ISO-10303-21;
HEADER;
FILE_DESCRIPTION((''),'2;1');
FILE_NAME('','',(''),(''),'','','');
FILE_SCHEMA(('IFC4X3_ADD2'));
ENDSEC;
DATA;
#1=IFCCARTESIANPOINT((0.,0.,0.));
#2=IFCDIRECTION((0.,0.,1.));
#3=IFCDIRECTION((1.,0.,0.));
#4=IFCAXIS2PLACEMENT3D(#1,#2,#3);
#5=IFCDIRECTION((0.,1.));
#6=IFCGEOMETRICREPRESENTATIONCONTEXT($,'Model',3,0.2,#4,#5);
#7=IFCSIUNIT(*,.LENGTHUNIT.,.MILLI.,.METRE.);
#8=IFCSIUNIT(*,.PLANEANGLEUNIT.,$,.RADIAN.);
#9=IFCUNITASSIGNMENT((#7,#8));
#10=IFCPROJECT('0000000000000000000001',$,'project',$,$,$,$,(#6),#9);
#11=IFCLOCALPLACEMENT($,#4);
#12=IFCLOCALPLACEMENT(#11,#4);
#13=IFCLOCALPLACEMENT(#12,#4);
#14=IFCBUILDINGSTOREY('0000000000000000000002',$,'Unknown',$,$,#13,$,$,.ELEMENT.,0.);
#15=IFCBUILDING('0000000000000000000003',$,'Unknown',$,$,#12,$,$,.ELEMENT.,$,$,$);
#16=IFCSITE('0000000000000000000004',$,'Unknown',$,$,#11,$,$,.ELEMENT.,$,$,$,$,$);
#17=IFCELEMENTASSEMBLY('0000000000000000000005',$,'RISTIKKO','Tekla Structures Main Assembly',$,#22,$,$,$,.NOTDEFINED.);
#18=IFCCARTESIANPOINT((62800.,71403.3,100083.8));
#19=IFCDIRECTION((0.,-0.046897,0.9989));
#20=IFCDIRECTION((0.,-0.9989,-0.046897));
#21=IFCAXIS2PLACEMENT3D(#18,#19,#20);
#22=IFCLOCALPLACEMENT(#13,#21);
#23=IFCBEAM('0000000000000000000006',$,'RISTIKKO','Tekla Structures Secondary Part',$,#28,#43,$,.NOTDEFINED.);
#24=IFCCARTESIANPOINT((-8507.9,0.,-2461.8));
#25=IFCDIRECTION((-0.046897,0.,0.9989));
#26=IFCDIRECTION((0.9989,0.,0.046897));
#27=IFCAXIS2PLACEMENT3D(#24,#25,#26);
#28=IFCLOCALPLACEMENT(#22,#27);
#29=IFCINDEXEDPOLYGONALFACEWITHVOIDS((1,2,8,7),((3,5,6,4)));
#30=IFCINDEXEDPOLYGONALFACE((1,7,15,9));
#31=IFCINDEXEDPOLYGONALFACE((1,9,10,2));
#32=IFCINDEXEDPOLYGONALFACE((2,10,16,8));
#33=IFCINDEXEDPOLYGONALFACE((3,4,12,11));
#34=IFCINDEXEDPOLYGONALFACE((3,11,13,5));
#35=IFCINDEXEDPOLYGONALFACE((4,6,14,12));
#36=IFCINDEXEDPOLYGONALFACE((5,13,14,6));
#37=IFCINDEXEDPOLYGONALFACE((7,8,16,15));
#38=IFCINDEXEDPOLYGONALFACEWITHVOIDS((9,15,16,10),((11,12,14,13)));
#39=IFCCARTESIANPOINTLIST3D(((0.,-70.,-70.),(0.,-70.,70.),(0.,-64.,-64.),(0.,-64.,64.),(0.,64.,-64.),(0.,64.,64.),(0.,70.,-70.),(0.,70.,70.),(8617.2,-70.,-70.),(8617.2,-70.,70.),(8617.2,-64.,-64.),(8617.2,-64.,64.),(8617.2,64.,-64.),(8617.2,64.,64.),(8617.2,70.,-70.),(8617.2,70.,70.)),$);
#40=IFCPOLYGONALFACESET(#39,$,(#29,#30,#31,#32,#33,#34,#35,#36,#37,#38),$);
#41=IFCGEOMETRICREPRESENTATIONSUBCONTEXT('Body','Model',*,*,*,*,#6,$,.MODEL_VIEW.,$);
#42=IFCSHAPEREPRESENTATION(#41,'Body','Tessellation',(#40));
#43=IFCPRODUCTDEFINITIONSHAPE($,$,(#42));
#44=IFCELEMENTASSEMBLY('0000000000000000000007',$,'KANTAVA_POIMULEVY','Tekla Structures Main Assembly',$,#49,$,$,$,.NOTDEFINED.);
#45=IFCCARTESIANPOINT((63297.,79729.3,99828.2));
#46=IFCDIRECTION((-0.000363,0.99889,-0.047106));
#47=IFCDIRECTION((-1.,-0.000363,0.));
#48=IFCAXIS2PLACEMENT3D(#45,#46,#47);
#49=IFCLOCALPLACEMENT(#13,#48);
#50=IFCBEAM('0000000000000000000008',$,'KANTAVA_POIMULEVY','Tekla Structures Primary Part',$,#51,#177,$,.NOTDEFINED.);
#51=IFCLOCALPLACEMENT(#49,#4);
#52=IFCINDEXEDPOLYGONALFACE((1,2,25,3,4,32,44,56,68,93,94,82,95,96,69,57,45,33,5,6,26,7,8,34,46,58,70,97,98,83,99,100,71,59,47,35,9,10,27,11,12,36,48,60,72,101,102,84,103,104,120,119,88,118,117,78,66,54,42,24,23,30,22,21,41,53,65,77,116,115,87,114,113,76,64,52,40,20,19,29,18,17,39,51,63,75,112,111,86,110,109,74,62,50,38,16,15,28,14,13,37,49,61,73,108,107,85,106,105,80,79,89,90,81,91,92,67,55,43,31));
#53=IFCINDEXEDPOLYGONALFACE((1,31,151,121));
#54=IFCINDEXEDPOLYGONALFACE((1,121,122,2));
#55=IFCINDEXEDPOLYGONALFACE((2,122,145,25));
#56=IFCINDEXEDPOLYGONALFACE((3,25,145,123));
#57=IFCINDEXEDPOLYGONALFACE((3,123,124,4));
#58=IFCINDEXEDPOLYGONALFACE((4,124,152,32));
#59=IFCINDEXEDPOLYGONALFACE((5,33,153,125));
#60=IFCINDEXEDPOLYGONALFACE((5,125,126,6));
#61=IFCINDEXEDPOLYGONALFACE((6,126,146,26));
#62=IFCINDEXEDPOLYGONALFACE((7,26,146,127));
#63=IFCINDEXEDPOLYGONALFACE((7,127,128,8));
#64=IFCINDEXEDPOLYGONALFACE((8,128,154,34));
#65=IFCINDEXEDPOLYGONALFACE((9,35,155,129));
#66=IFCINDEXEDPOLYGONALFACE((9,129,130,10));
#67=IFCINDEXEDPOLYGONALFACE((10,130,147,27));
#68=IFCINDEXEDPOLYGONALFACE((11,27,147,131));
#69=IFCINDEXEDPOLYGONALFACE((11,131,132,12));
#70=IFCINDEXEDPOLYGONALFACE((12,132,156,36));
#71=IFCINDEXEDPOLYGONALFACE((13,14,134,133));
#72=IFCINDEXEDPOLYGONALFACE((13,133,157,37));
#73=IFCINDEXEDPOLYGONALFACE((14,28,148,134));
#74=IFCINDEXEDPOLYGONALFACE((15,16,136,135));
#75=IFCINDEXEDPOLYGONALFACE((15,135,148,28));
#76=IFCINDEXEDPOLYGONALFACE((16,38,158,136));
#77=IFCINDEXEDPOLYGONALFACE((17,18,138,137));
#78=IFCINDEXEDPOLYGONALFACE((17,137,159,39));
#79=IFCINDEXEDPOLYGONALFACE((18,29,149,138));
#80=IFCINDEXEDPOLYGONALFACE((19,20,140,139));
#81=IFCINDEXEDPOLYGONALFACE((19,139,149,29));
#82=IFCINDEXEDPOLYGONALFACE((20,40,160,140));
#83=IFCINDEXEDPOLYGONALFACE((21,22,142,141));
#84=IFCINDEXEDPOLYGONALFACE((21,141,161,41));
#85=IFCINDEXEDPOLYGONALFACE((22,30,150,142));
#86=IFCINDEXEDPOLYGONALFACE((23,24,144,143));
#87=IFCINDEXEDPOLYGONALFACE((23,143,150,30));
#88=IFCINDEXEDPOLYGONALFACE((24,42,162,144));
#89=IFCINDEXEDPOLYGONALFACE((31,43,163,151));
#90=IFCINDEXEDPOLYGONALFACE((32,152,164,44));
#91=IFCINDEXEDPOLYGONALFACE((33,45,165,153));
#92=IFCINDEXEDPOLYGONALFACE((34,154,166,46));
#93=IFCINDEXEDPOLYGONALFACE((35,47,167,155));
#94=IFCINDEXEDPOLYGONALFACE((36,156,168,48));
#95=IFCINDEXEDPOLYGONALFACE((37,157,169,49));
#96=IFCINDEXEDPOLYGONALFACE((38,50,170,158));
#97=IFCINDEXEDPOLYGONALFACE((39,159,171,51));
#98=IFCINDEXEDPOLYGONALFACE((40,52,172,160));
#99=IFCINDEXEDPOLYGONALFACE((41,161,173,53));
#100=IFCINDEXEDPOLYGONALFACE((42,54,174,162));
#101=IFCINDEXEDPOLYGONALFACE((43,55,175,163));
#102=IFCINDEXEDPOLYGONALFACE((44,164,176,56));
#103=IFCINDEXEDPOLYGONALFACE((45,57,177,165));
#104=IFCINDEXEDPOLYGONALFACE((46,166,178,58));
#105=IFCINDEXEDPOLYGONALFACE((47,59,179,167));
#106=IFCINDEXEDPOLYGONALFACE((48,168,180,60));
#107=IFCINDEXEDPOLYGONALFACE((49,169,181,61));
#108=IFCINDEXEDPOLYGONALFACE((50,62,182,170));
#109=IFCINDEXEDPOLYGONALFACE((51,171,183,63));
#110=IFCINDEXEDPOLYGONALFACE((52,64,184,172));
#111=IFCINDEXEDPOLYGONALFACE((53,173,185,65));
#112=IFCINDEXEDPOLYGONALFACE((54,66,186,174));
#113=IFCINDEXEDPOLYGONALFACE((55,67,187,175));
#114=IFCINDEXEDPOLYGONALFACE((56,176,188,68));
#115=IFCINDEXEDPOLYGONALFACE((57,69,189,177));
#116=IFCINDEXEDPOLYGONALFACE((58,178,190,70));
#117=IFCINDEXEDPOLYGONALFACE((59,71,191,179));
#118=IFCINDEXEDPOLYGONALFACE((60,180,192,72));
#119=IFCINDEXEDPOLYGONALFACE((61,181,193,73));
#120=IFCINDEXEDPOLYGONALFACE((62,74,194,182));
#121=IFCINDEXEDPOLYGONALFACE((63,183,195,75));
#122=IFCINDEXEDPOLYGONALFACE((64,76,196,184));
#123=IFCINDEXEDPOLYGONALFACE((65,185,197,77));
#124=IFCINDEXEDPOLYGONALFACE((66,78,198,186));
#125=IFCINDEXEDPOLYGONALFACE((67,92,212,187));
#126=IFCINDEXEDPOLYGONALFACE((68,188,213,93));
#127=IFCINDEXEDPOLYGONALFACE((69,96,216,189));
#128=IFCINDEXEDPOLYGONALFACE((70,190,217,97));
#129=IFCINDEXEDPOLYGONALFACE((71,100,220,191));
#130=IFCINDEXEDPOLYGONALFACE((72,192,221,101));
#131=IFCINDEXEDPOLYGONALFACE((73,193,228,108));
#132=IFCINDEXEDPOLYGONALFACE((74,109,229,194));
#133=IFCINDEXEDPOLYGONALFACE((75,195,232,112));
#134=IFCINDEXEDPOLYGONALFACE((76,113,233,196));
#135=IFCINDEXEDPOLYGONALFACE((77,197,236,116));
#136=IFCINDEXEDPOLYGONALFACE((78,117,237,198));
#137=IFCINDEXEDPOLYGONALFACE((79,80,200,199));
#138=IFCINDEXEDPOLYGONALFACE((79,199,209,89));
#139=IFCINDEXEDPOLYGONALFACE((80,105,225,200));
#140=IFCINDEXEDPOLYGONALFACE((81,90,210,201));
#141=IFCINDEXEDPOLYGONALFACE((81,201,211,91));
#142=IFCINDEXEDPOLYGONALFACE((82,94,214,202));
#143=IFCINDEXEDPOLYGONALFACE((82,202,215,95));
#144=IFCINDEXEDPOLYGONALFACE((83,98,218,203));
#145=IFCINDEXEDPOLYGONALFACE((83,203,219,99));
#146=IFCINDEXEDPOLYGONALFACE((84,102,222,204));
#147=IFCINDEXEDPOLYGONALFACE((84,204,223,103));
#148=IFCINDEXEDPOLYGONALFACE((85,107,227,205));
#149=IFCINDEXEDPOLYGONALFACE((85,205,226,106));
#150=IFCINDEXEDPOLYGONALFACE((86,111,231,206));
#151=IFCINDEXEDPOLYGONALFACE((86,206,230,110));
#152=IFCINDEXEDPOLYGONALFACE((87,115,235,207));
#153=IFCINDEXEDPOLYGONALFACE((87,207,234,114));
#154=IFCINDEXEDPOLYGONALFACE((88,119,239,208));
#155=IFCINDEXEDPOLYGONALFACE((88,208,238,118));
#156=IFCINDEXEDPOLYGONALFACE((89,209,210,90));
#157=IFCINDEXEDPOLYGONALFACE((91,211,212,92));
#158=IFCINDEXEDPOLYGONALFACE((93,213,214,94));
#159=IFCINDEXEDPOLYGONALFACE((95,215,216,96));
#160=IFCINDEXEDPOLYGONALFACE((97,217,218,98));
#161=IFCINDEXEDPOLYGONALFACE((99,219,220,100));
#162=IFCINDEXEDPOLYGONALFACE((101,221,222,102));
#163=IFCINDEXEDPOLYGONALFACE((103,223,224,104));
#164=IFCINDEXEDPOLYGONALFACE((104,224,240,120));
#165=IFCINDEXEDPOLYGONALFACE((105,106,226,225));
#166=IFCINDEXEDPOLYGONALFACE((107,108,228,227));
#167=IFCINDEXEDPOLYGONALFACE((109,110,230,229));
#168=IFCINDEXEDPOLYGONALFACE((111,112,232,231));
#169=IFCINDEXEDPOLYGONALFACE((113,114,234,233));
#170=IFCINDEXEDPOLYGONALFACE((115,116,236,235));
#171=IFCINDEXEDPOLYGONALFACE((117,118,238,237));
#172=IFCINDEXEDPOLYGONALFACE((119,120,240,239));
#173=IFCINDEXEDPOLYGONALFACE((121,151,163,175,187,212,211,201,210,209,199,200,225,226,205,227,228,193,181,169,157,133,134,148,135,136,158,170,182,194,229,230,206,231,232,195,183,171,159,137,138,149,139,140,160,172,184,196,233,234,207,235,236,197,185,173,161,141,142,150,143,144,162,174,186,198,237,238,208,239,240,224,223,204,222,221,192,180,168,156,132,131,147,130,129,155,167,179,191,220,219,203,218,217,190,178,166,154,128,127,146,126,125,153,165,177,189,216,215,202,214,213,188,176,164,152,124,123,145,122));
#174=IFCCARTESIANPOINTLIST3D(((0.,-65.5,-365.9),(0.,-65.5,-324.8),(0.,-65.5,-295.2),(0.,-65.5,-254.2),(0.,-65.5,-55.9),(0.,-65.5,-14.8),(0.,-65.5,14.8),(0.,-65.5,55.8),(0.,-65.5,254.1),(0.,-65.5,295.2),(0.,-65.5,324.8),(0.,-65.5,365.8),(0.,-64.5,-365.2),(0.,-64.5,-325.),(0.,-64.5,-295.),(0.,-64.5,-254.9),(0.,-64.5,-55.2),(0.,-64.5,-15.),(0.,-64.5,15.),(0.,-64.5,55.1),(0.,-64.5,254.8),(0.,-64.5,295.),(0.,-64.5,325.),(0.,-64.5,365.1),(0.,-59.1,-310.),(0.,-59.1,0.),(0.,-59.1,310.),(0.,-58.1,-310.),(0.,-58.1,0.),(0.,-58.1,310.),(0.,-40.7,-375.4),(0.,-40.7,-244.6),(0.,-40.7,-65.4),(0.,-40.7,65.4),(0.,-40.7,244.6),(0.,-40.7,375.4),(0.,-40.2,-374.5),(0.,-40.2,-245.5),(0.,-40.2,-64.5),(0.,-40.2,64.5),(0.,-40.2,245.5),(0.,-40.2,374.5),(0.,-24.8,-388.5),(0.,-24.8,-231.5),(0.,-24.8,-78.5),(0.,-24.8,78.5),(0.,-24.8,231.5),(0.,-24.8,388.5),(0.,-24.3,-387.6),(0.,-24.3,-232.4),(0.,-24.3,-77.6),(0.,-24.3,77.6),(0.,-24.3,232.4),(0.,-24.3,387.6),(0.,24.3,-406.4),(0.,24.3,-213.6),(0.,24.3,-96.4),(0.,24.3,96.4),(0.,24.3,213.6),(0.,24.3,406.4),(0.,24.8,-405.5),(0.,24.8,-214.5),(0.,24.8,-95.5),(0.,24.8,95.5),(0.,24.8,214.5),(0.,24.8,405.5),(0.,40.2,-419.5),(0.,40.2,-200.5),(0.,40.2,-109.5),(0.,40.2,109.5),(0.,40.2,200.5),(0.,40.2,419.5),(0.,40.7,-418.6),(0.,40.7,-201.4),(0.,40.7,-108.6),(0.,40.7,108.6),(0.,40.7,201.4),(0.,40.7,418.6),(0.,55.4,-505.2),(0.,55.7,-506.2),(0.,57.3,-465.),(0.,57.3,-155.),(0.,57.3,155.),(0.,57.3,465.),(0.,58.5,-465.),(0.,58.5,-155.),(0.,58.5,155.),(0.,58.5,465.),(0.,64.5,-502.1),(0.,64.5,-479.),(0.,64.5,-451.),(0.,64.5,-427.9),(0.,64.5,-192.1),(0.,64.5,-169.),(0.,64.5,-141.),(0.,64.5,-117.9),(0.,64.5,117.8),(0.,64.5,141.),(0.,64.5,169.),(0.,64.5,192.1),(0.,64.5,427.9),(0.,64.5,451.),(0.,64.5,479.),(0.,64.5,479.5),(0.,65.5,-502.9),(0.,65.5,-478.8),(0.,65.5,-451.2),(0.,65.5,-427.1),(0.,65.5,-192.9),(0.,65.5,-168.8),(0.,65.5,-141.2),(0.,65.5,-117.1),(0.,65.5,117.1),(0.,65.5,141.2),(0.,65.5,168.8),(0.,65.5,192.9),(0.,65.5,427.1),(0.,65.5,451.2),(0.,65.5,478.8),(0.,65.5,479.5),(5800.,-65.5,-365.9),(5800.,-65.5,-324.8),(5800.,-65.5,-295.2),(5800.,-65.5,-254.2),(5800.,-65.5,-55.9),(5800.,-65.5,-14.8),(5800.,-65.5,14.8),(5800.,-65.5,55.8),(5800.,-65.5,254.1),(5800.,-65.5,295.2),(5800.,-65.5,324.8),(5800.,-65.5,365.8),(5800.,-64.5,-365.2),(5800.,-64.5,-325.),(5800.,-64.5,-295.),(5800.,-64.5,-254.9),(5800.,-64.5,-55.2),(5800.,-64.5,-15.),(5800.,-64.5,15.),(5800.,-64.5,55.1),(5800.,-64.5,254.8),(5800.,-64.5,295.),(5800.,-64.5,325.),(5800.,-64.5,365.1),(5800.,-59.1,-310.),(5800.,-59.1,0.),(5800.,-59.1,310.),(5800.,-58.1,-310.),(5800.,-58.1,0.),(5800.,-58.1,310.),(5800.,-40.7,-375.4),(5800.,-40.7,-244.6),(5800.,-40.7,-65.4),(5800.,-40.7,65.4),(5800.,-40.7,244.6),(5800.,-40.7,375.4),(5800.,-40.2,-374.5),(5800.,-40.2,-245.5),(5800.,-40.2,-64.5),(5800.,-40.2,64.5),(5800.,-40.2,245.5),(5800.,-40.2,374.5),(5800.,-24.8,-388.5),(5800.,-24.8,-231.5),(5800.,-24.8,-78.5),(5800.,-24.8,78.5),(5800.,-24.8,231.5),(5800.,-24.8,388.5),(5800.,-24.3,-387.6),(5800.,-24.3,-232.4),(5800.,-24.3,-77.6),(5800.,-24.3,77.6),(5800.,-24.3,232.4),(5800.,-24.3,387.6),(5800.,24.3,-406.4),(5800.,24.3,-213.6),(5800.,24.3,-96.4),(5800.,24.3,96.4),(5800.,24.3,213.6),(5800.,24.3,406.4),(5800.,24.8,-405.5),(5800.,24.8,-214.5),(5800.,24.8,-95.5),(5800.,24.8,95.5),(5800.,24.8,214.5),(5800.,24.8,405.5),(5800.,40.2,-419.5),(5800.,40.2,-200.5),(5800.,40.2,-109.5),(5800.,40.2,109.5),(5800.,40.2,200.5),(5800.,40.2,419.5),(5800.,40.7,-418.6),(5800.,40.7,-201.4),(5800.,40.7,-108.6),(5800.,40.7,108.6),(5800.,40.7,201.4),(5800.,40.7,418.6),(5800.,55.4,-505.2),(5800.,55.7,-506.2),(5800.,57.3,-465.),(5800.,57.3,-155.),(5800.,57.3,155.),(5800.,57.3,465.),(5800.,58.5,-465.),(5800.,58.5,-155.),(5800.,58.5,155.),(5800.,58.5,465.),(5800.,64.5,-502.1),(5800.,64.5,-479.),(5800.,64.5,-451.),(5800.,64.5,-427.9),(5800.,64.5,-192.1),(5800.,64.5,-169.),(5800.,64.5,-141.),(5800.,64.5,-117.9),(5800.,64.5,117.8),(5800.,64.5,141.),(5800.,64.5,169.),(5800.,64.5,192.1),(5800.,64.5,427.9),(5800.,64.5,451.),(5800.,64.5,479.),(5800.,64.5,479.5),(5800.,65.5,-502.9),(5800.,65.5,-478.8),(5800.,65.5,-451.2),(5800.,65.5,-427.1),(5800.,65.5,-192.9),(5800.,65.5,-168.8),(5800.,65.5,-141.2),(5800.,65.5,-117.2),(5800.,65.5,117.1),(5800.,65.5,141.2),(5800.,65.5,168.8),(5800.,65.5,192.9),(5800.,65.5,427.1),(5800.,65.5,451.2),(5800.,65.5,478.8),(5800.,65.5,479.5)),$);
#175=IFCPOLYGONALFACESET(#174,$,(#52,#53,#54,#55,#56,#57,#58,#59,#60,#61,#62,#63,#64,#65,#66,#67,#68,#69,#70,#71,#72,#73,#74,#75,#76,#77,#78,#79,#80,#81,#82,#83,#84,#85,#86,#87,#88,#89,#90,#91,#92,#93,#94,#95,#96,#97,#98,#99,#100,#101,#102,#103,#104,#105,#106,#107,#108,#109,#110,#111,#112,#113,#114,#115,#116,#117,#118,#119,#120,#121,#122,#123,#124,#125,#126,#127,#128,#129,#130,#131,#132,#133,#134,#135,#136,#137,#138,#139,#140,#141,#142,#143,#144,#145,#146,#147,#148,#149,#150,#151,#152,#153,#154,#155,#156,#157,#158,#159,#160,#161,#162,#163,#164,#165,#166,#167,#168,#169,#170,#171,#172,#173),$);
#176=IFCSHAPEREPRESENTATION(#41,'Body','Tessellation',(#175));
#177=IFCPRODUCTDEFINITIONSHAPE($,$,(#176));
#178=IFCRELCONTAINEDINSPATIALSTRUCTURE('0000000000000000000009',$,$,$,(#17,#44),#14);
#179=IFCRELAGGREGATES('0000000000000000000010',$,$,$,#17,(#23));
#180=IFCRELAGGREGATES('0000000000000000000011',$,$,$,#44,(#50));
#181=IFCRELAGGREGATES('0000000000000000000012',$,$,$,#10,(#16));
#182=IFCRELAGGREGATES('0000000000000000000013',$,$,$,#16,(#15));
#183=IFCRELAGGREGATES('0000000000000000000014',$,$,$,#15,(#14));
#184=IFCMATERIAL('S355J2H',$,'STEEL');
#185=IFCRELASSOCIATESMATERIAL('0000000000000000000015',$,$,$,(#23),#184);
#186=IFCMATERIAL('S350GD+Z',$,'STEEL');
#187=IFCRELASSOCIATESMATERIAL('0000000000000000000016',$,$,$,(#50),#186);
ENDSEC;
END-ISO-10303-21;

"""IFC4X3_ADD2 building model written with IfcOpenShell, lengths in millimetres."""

from ifc_helpers import new_model, si_unit, direction, frame, origin_with_axes, place, context, subcontext, project, spatial, line, indexed_curve, outline, extrude, material, element, aggregate, save


model = new_model("IFC4X3_ADD2")

# Units and contexts
model_context = context("Model", 3, precision=0.2, world=origin_with_axes(), true_north=direction((0.0, 1.0)))
body_context = subcontext(model_context, "Body", "Model", "MODEL_VIEW")
ifc_project = project(units=[si_unit("LENGTHUNIT", "METRE", prefix="MILLI"), si_unit("PLANEANGLEUNIT", "RADIAN")], contexts=[model_context])

# Site, building, storey
site_placement = place(None, origin_with_axes())
site = spatial("IfcSite", under=ifc_project, at=site_placement, Name="Unknown", CompositionType="ELEMENT")
building_placement = place(site_placement, origin_with_axes())
building = spatial("IfcBuilding", under=site, at=building_placement, Name="Unknown", CompositionType="ELEMENT")
storey_placement = place(building_placement, origin_with_axes())
storey = spatial("IfcBuildingStorey", under=building, at=storey_placement, Name="Unknown", CompositionType="ELEMENT", Elevation=0.0)

# Element assembly, beam
assembly_1_placement = place(storey_placement, frame((62800.0, 71403.3, 100083.8), z_axis=(0.0, -0.046897, 0.9989), x_axis=(0.0, -0.9989, -0.046897)))
assembly_1 = element("IfcElementAssembly", 1, at=assembly_1_placement, inside=storey, Name="RISTIKKO", Description="Tekla Structures Main Assembly", PredefinedType="NOTDEFINED")
ifc_material_1 = material(Name="S355J2H", Category="STEEL")
beam_1_placement = place(assembly_1_placement, frame((-8507.9, 0.0, -2461.8), z_axis=(-0.046897, 0.0, 0.9989), x_axis=(0.9989, 0.0, 0.046897)))
beam_1 = element("IfcBeam", 2, at=beam_1_placement, material=ifc_material_1, Name="RISTIKKO", Description="Tekla Structures Secondary Part", PredefinedType="NOTDEFINED", context=body_context, shape_type="SolidModel", body=[
    extrude(outline(indexed_curve([(-70.0, -70.0), (70.0, -70.0), (70.0, 70.0), (-70.0, 70.0)], segments=[line(1, 2, 3, 4, 1)]), holes=[indexed_curve([(-64.0, -64.0), (-64.0, 64.0), (64.0, 64.0), (64.0, -64.0)], segments=[line(1, 2, 3, 4, 1)])]), frame((0.0, 0.0, 0.0), z_axis=(-1.0, 0.0, 0.0), x_axis=(0.0, 0.0, 1.0)), (0.0, 0.0, -1.0), 8617.2),
])
aggregate(assembly_1, [beam_1])

# Element assembly, beam
ifc_material_2 = material(Name="S350GD+Z", Category="STEEL")
assembly_2_placement = place(storey_placement, frame((63297.0, 79729.3, 99828.2), z_axis=(-0.000363, 0.99889, -0.047106), x_axis=(-1.0, -0.000363, 0.0)))
assembly_2 = element("IfcElementAssembly", 3, at=assembly_2_placement, inside=storey, Name="KANTAVA_POIMULEVY", Description="Tekla Structures Main Assembly", PredefinedType="NOTDEFINED")
beam_2_placement = place(assembly_2_placement, origin_with_axes())
beam_2 = element("IfcBeam", 4, at=beam_2_placement, material=ifc_material_2, Name="KANTAVA_POIMULEVY", Description="Tekla Structures Primary Part", PredefinedType="NOTDEFINED", context=body_context, shape_type="SolidModel", body=[
    extrude(outline(indexed_curve([(479.5, 65.5), (478.8, 65.5), (465.0, 58.5), (451.2, 65.5), (427.1, 65.5), (418.6, 40.7), (405.5, 24.8), (387.6, -24.3), (374.5, -40.2), (365.1, -64.5), (325.0, -64.5), (310.0, -58.1), (295.0, -64.5), (254.8, -64.5), (245.5, -40.2), (232.4, -24.3), (214.5, 24.8), (201.4, 40.7), (192.9, 65.5), (168.8, 65.5), (155.0, 58.5), (141.2, 65.5), (117.1, 65.5), (108.6, 40.7), (95.5, 24.8), (77.6, -24.3), (64.5, -40.2), (55.1, -64.5), (15.0, -64.5), (0.0, -58.1), (-15.0, -64.5), (-55.2, -64.5), (-64.5, -40.2), (-77.6, -24.3), (-95.5, 24.8), (-108.6, 40.7), (-117.2, 65.5), (-141.2, 65.5), (-155.0, 58.5), (-168.8, 65.5), (-192.9, 65.5), (-201.4, 40.7), (-214.5, 24.8), (-232.4, -24.3), (-245.5, -40.2), (-254.9, -64.5), (-295.0, -64.5), (-310.0, -58.1), (-325.0, -64.5), (-365.2, -64.5), (-374.5, -40.2), (-387.6, -24.3), (-405.5, 24.8), (-418.6, 40.7), (-427.1, 65.5), (-451.2, 65.5), (-465.0, 58.5), (-478.8, 65.5), (-502.9, 65.5), (-506.2, 55.7), (-505.2, 55.4), (-502.1, 64.5), (-479.0, 64.5), (-465.0, 57.3), (-451.0, 64.5), (-427.9, 64.5), (-419.5, 40.2), (-406.4, 24.3), (-388.5, -24.8), (-375.4, -40.7), (-365.9, -65.5), (-324.8, -65.5), (-310.0, -59.1), (-295.2, -65.5), (-254.2, -65.5), (-244.6, -40.7), (-231.5, -24.8), (-213.6, 24.3), (-200.5, 40.2), (-192.1, 64.5), (-169.0, 64.5), (-155.0, 57.3), (-141.0, 64.5), (-117.9, 64.5), (-109.5, 40.2), (-96.4, 24.3), (-78.5, -24.8), (-65.4, -40.7), (-55.9, -65.5), (-14.8, -65.5), (0.0, -59.1), (14.8, -65.5), (55.8, -65.5), (65.4, -40.7), (78.5, -24.8), (96.4, 24.3), (109.5, 40.2), (117.8, 64.5), (141.0, 64.5), (155.0, 57.3), (169.0, 64.5), (192.1, 64.5), (200.5, 40.2), (213.6, 24.3), (231.5, -24.8), (244.6, -40.7), (254.1, -65.5), (295.2, -65.5), (310.0, -59.1), (324.8, -65.5), (365.8, -65.5), (375.4, -40.7), (388.5, -24.8), (406.4, 24.3), (419.5, 40.2), (427.9, 64.5), (451.0, 64.5), (465.0, 57.3), (479.0, 64.5), (479.5, 64.5)], segments=[line(1, 2, 3, 4, 5, 6, 7, 8, 9, 10, 11, 12, 13, 14, 15, 16, 17, 18, 19, 20, 21, 22, 23, 24, 25, 26, 27, 28, 29, 30, 31, 32, 33, 34, 35, 36, 37, 38, 39, 40, 41, 42, 43, 44, 45, 46, 47, 48, 49, 50, 51, 52, 53, 54, 55, 56, 57, 58, 59, 60, 61, 62, 63, 64, 65, 66, 67, 68, 69, 70, 71, 72, 73, 74, 75, 76, 77, 78, 79, 80, 81, 82, 83, 84, 85, 86, 87, 88, 89, 90, 91, 92, 93, 94, 95, 96, 97, 98, 99, 100, 101, 102, 103, 104, 105, 106, 107, 108, 109, 110, 111, 112, 113, 114, 115, 116, 117, 118, 119, 120, 1)])), frame((0.0, 0.0, 0.0), z_axis=(-1.0, 0.0, 0.0), x_axis=(0.0, 0.0, 1.0)), (0.0, 0.0, -1.0), 5800.0),
])
aggregate(assembly_2, [beam_2])

save(model, "model.ifc")
